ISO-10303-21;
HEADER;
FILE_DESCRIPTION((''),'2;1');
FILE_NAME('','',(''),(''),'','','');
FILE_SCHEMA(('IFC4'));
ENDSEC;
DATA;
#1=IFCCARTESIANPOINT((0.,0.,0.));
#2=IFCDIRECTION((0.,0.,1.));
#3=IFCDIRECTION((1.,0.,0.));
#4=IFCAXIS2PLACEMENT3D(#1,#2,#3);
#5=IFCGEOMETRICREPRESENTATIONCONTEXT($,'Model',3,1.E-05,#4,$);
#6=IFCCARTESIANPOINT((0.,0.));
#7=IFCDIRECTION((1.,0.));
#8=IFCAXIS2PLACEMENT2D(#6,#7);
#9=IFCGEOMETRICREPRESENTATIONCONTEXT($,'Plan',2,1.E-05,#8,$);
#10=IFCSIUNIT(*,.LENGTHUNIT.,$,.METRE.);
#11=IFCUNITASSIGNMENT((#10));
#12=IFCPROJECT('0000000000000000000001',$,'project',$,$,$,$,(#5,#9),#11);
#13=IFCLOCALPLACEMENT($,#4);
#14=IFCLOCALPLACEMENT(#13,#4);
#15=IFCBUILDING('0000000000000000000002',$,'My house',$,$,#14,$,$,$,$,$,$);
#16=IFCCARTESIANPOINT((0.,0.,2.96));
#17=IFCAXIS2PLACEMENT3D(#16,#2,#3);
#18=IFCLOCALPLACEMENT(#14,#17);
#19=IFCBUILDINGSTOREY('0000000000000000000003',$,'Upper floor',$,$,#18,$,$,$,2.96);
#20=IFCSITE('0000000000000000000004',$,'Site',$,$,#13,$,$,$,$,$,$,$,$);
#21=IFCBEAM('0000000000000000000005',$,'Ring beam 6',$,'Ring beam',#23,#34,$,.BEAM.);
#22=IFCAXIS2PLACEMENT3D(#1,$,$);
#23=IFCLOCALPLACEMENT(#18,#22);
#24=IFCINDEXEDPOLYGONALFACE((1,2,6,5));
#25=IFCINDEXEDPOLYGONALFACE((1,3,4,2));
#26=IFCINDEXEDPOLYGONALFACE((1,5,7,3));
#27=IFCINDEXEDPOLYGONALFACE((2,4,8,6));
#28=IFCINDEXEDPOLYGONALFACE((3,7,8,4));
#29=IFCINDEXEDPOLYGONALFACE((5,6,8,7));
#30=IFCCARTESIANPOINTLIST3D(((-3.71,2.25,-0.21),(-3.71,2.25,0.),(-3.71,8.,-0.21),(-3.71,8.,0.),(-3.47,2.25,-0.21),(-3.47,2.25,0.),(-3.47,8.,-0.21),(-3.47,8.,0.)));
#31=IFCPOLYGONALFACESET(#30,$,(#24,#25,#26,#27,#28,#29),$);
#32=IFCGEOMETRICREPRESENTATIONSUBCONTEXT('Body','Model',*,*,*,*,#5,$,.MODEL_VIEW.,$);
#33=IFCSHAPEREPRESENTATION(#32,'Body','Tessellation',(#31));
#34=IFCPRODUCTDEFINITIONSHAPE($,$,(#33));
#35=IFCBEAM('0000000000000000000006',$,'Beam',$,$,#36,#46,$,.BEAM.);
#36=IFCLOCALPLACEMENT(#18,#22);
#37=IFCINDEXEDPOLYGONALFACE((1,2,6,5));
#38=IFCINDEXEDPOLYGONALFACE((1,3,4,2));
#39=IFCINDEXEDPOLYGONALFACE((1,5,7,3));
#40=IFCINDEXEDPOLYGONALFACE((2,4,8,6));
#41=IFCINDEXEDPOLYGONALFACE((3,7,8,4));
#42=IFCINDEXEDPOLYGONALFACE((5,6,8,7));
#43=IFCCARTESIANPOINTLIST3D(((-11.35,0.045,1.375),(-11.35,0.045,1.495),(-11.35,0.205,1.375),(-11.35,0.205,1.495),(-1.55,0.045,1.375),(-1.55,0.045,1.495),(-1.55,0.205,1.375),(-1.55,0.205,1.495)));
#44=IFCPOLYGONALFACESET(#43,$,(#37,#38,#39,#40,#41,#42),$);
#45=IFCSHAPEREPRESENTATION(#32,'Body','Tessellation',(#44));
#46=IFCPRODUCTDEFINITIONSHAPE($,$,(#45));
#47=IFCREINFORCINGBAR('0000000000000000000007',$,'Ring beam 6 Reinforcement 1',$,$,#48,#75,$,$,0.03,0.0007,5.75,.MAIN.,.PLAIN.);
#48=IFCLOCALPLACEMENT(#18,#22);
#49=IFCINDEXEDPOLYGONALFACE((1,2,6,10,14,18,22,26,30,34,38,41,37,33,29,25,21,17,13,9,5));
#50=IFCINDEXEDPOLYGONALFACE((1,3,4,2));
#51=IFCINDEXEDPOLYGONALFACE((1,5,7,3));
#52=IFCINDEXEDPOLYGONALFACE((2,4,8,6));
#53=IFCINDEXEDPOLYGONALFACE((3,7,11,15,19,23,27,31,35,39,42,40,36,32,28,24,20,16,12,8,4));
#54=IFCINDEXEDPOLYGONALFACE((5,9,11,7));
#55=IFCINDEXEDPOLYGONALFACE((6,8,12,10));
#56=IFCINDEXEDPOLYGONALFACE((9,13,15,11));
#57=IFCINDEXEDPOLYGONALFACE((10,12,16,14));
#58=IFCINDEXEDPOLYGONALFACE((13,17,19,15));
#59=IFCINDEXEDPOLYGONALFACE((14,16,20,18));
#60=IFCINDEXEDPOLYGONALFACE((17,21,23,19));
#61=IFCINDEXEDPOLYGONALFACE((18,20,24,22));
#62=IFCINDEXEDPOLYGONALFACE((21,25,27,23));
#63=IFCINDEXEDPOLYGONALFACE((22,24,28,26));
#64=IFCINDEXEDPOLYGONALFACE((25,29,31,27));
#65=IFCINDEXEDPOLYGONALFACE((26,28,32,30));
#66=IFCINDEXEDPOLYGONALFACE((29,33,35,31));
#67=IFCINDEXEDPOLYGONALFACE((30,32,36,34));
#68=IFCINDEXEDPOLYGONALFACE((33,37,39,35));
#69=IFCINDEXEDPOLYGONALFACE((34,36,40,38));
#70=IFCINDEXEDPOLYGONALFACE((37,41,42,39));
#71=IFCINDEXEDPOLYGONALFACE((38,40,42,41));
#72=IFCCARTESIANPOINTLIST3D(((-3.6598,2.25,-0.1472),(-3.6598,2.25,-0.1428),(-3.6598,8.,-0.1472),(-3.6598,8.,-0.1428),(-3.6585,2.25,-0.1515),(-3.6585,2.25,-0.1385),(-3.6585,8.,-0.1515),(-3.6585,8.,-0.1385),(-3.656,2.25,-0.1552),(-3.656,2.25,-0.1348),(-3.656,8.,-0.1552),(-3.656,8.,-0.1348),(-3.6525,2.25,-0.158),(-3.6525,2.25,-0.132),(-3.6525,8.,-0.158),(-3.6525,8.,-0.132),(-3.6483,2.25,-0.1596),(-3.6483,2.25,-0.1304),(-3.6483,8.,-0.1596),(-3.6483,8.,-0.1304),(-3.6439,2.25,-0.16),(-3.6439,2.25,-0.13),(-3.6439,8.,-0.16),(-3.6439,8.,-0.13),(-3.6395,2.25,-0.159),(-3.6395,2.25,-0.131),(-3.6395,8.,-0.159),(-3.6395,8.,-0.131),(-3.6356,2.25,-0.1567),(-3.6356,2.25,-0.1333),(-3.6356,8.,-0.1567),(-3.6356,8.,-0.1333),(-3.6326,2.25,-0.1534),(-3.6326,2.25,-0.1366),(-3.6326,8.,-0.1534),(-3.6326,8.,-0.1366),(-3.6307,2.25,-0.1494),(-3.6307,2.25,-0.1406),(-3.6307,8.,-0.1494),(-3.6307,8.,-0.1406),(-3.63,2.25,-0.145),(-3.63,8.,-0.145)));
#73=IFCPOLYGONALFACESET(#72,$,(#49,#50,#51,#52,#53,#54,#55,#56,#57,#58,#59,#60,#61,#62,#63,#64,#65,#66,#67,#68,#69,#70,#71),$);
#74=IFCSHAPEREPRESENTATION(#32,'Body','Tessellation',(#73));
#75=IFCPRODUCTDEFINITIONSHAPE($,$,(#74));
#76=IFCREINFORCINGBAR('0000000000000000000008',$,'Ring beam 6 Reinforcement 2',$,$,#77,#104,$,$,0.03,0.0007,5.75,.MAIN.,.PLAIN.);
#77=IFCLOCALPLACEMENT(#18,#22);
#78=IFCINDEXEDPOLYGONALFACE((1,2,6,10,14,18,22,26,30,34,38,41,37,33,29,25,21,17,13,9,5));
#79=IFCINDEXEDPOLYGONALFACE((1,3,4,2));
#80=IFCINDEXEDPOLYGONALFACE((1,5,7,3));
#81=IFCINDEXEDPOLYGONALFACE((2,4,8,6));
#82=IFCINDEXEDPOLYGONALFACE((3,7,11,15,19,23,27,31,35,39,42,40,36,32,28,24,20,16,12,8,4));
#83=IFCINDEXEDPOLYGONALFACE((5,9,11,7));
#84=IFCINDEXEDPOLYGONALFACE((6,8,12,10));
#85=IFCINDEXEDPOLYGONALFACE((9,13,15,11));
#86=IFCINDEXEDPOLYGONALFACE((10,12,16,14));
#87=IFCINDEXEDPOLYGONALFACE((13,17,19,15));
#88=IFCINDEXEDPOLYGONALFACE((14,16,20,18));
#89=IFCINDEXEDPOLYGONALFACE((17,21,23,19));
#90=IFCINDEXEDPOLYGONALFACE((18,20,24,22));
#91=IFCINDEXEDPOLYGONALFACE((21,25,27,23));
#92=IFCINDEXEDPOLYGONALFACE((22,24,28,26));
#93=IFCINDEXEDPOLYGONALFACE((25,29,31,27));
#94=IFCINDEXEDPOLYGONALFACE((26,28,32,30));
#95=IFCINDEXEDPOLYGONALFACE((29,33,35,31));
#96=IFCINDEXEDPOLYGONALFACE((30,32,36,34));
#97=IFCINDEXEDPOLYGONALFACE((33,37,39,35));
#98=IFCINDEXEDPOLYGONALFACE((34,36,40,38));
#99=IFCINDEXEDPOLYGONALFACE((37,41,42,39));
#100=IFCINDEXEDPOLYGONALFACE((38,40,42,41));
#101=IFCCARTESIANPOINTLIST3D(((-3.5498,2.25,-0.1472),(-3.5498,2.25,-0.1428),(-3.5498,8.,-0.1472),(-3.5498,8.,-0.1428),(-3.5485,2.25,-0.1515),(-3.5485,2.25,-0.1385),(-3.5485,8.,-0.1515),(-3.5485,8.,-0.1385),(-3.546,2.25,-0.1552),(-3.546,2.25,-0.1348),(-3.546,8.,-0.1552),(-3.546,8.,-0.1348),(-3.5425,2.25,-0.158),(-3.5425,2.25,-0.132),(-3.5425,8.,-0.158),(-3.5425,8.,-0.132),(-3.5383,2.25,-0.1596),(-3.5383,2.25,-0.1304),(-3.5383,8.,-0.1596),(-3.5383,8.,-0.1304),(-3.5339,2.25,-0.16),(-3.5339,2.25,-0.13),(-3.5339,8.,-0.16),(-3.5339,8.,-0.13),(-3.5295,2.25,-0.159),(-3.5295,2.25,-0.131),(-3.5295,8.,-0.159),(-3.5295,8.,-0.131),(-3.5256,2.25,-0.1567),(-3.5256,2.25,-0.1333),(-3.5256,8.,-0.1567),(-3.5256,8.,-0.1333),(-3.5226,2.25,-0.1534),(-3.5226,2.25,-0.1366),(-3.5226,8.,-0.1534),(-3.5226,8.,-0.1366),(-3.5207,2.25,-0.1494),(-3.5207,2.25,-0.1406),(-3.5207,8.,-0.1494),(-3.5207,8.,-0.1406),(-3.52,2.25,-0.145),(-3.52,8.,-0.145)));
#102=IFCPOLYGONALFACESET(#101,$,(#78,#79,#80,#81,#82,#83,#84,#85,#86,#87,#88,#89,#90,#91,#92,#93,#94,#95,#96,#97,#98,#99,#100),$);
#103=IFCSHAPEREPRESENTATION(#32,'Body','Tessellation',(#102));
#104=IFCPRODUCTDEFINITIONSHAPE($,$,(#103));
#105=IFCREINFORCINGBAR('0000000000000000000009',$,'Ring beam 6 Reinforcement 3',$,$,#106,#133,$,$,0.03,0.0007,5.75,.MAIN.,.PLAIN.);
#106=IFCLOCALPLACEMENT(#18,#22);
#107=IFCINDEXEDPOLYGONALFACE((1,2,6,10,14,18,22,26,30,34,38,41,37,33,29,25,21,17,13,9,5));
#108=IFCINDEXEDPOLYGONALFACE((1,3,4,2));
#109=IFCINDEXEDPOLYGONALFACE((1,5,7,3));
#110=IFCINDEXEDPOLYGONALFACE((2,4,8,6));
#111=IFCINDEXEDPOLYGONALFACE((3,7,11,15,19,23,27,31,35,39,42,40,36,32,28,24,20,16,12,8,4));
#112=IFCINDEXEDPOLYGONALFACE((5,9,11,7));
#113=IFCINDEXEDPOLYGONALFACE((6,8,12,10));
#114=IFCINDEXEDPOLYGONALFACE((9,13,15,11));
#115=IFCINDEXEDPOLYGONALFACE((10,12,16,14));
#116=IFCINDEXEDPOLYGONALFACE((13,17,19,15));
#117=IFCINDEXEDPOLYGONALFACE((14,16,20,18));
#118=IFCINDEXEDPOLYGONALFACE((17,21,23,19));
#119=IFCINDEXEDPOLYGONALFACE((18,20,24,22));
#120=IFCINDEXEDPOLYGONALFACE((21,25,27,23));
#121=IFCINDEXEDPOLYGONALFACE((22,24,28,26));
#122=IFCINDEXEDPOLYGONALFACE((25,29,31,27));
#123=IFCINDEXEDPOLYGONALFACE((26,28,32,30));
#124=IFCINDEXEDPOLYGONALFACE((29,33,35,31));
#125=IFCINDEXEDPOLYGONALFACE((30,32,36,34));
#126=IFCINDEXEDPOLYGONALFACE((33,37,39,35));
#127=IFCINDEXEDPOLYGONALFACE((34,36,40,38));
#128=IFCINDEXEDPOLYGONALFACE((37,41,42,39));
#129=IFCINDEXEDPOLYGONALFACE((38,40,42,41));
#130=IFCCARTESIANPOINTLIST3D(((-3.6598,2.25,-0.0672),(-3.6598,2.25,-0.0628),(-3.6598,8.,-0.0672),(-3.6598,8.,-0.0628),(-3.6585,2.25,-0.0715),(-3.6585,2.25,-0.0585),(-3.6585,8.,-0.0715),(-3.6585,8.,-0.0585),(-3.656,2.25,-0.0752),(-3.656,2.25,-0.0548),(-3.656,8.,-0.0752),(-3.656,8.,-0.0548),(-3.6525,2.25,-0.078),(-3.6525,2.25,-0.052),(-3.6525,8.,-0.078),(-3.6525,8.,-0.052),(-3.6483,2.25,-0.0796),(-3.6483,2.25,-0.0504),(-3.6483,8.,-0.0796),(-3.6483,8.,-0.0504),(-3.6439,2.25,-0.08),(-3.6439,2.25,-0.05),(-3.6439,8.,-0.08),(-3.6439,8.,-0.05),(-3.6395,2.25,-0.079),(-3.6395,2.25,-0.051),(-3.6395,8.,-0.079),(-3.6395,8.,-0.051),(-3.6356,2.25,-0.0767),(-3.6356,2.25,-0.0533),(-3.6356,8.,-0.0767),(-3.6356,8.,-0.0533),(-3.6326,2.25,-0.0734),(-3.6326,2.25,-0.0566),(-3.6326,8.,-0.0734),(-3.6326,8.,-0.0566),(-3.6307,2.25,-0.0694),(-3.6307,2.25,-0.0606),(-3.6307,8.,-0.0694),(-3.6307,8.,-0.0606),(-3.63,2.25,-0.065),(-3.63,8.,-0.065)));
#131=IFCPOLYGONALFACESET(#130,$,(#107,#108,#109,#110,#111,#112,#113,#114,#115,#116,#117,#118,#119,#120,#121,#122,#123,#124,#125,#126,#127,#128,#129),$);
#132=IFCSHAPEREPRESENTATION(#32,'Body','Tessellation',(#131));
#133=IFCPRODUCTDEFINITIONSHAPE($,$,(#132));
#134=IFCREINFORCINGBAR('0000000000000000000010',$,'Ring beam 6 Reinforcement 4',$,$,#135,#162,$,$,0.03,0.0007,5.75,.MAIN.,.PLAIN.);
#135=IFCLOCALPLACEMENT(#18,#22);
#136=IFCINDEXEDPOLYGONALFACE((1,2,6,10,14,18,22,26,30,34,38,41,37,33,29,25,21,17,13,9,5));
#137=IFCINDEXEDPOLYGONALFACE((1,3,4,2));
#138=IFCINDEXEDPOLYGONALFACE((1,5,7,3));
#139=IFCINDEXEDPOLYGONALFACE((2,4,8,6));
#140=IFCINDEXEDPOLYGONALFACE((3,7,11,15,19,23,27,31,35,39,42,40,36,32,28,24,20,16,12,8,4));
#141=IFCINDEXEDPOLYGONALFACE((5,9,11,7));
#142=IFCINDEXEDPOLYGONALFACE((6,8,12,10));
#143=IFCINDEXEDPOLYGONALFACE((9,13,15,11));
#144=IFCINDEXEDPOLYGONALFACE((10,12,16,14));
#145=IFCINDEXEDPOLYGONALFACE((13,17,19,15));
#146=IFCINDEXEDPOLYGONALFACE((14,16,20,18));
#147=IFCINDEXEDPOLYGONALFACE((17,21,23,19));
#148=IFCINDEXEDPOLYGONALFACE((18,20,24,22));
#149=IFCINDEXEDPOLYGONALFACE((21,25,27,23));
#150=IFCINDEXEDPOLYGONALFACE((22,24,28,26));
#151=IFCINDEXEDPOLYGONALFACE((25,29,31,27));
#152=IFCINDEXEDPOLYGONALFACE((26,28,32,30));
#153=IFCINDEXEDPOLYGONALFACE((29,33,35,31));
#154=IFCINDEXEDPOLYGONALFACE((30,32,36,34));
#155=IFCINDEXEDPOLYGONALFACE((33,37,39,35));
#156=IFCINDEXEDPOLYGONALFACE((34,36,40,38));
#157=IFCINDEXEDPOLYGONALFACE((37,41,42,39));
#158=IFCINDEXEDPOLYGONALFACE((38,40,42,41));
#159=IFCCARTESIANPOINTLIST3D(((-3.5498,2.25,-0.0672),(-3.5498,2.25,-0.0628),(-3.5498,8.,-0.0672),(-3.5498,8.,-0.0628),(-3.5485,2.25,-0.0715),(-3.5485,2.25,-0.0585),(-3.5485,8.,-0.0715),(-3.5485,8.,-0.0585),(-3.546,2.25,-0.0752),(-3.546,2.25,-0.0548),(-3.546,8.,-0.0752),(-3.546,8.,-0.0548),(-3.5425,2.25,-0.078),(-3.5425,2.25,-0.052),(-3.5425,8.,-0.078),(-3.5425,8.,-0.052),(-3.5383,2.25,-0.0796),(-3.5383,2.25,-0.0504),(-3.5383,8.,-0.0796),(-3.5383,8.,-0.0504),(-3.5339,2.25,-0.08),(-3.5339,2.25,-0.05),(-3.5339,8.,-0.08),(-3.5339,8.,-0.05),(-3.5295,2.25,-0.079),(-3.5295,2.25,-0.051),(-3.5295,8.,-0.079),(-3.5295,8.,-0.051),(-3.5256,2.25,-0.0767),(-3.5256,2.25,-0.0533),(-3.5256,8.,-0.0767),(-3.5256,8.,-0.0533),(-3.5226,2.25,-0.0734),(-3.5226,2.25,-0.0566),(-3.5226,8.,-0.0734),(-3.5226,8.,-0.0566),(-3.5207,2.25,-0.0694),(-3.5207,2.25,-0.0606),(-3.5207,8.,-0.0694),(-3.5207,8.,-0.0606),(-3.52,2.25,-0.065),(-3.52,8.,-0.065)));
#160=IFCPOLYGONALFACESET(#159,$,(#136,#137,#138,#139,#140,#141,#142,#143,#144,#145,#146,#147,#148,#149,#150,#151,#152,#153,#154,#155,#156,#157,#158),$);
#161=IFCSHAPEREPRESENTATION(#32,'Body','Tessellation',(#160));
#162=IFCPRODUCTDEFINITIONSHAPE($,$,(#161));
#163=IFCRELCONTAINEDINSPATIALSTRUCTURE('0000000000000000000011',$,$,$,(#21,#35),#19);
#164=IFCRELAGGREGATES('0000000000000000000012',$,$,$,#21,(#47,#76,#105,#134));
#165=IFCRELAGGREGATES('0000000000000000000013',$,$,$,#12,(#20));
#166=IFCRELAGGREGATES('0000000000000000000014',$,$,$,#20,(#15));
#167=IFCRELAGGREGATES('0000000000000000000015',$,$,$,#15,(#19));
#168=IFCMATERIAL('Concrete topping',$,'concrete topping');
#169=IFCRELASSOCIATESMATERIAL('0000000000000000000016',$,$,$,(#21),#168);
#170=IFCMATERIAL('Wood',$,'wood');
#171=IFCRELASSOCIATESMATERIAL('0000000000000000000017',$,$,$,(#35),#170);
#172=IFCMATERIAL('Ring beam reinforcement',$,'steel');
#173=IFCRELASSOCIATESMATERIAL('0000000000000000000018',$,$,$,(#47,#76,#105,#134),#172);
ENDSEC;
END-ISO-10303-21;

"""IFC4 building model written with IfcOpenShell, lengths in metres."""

from ifc_helpers import new_model, si_unit, frame, origin_with_axes, origin_2d, origin_2d_with_axis, place, context, subcontext, project, spatial, circle_curve, rectangle, outline, extrude, source, transform, mapped, material, element, aggregate, save


model = new_model("IFC4")

# Units and contexts
model_context = context("Model", 3, precision=1e-05, world=origin_with_axes())
plan_context = context("Plan", 2, precision=1e-05, world=origin_2d_with_axis())
body_context = subcontext(model_context, "Body", "Model", "MODEL_VIEW")
ifc_project = project(units=[si_unit("LENGTHUNIT", "METRE")], contexts=[model_context, plan_context])

# Site, building, storey
site_placement = place(None, origin_with_axes())
site = spatial("IfcSite", under=ifc_project, at=site_placement, Name="Site")
building_placement = place(site_placement, origin_with_axes())
building = spatial("IfcBuilding", under=site, at=building_placement, Name="My house")
storey_placement = place(building_placement, frame((0.0, 0.0, 2.96), z_axis=(0.0, 0.0, 1.0), x_axis=(1.0, 0.0, 0.0)))
storey = spatial("IfcBuildingStorey", under=building, at=storey_placement, Name="Upper floor", Elevation=2.96)

# Beams
ifc_material_1 = material(Name="Concrete topping", Category="concrete topping")
shared_shape_1 = source(origin_with_axes(), body_context, "Body", "SweptSolid", [
    extrude(rectangle(XDim=0.24, YDim=0.21), frame((0.0, 0.0, 0.0), z_axis=(1.0, 0.0, 0.0), x_axis=(0.0, 1.0, 0.0)), (0.0, 0.0, 1.0), 5.75),
])
beam_1_placement = place(storey_placement, frame((-3.59, 2.25, -0.105), z_axis=(0.0, 0.0, 1.0), x_axis=(0.0, -1.0, 0.0)))
beam_1 = element("IfcBeam", 1, at=beam_1_placement, inside=storey, material=ifc_material_1, Name="Ring beam 6", ObjectType="Ring beam", PredefinedType="BEAM", context=body_context, shape_type="MappedRepresentation", body=[
    mapped(shared_shape_1, transform((0.0, 0.0, 0.0), x_axis=(-1.0, 0.0, 0.0), y_axis=(0.0, 1.0, 0.0), z_axis=(0.0, 0.0, 1.0), scale=1.0)),
])
ifc_material_2 = material(Name="Wood", Category="wood")
shared_shape_2 = source(origin_with_axes(), body_context, "Body", "SweptSolid", [
    extrude(rectangle(XDim=0.16, YDim=0.12), frame((0.0, 0.0, 0.0), z_axis=(1.0, 0.0, 0.0), x_axis=(0.0, 1.0, 0.0)), (0.0, 0.0, 1.0), 9.8),
])
beam_2_placement = place(storey_placement, frame((-1.55, 0.125, 1.435), z_axis=(0.0, 0.0, 1.0), x_axis=(1.0, 0.0, 0.0)))
element("IfcBeam", 2, at=beam_2_placement, inside=storey, material=ifc_material_2, Name="Beam", PredefinedType="BEAM", context=body_context, shape_type="MappedRepresentation", body=[
    mapped(shared_shape_2, transform((0.0, 0.0, 0.0), x_axis=(-1.0, 0.0, 0.0), y_axis=(0.0, 1.0, 0.0), z_axis=(0.0, 0.0, 1.0), scale=1.0)),
])

# Reinforcing bars
ifc_material_3 = material(Name="Ring beam reinforcement", Category="steel")
shared_shape_3 = source(origin_with_axes(), body_context, "Body", "SweptSolid", [
    extrude(outline(circle_curve(origin_2d(), 0.015)), frame((0.0, 0.0, 0.0), z_axis=(1.0, 0.0, 0.0), x_axis=(0.0, 1.0, 0.0)), (0.0, 0.0, 1.0), 5.75),
])
reinforcing_bar_1_placement = place(beam_1_placement, frame((0.0, -0.055, -0.04), z_axis=(0.0, 0.0, 1.0), x_axis=(1.0, 0.0, 0.0)))
reinforcing_bar_1 = element("IfcReinforcingBar", 3, at=reinforcing_bar_1_placement, material=ifc_material_3, Name="Ring beam 6 Reinforcement 1", BarLength=5.75, BarSurface="PLAIN", CrossSectionArea=0.0007, NominalDiameter=0.03, PredefinedType="MAIN", context=body_context, shape_type="MappedRepresentation", body=[
    mapped(shared_shape_3, transform((0.0, 0.0, 0.0), x_axis=(-1.0, 0.0, 0.0), y_axis=(0.0, 1.0, 0.0), z_axis=(0.0, 0.0, 1.0), scale=1.0)),
])
shared_shape_4 = source(origin_with_axes(), body_context, "Body", "SweptSolid", [
    extrude(outline(circle_curve(origin_2d(), 0.015)), frame((0.0, 0.0, 0.0), z_axis=(1.0, 0.0, 0.0), x_axis=(0.0, 1.0, 0.0)), (0.0, 0.0, 1.0), 5.75),
])
reinforcing_bar_2_placement = place(beam_1_placement, frame((0.0, 0.055, -0.04), z_axis=(0.0, 0.0, 1.0), x_axis=(1.0, 0.0, 0.0)))
reinforcing_bar_2 = element("IfcReinforcingBar", 4, at=reinforcing_bar_2_placement, material=ifc_material_3, Name="Ring beam 6 Reinforcement 2", BarLength=5.75, BarSurface="PLAIN", CrossSectionArea=0.0007, NominalDiameter=0.03, PredefinedType="MAIN", context=body_context, shape_type="MappedRepresentation", body=[
    mapped(shared_shape_4, transform((0.0, 0.0, 0.0), x_axis=(-1.0, 0.0, 0.0), y_axis=(0.0, 1.0, 0.0), z_axis=(0.0, 0.0, 1.0), scale=1.0)),
])
shared_shape_5 = source(origin_with_axes(), body_context, "Body", "SweptSolid", [
    extrude(outline(circle_curve(origin_2d(), 0.015)), frame((0.0, 0.0, 0.0), z_axis=(1.0, 0.0, 0.0), x_axis=(0.0, 1.0, 0.0)), (0.0, 0.0, 1.0), 5.75),
])
reinforcing_bar_3_placement = place(beam_1_placement, frame((0.0, -0.055, 0.04), z_axis=(0.0, 0.0, 1.0), x_axis=(1.0, 0.0, 0.0)))
reinforcing_bar_3 = element("IfcReinforcingBar", 5, at=reinforcing_bar_3_placement, material=ifc_material_3, Name="Ring beam 6 Reinforcement 3", BarLength=5.75, BarSurface="PLAIN", CrossSectionArea=0.0007, NominalDiameter=0.03, PredefinedType="MAIN", context=body_context, shape_type="MappedRepresentation", body=[
    mapped(shared_shape_5, transform((0.0, 0.0, 0.0), x_axis=(-1.0, 0.0, 0.0), y_axis=(0.0, 1.0, 0.0), z_axis=(0.0, 0.0, 1.0), scale=1.0)),
])
shared_shape_6 = source(origin_with_axes(), body_context, "Body", "SweptSolid", [
    extrude(outline(circle_curve(origin_2d(), 0.015)), frame((0.0, 0.0, 0.0), z_axis=(1.0, 0.0, 0.0), x_axis=(0.0, 1.0, 0.0)), (0.0, 0.0, 1.0), 5.75),
])
reinforcing_bar_4_placement = place(beam_1_placement, frame((0.0, 0.055, 0.04), z_axis=(0.0, 0.0, 1.0), x_axis=(1.0, 0.0, 0.0)))
reinforcing_bar_4 = element("IfcReinforcingBar", 6, at=reinforcing_bar_4_placement, material=ifc_material_3, Name="Ring beam 6 Reinforcement 4", BarLength=5.75, BarSurface="PLAIN", CrossSectionArea=0.0007, NominalDiameter=0.03, PredefinedType="MAIN", context=body_context, shape_type="MappedRepresentation", body=[
    mapped(shared_shape_6, transform((0.0, 0.0, 0.0), x_axis=(-1.0, 0.0, 0.0), y_axis=(0.0, 1.0, 0.0), z_axis=(0.0, 0.0, 1.0), scale=1.0)),
])
aggregate(beam_1, [reinforcing_bar_1, reinforcing_bar_2, reinforcing_bar_3, reinforcing_bar_4])

save(model, "model.ifc")
